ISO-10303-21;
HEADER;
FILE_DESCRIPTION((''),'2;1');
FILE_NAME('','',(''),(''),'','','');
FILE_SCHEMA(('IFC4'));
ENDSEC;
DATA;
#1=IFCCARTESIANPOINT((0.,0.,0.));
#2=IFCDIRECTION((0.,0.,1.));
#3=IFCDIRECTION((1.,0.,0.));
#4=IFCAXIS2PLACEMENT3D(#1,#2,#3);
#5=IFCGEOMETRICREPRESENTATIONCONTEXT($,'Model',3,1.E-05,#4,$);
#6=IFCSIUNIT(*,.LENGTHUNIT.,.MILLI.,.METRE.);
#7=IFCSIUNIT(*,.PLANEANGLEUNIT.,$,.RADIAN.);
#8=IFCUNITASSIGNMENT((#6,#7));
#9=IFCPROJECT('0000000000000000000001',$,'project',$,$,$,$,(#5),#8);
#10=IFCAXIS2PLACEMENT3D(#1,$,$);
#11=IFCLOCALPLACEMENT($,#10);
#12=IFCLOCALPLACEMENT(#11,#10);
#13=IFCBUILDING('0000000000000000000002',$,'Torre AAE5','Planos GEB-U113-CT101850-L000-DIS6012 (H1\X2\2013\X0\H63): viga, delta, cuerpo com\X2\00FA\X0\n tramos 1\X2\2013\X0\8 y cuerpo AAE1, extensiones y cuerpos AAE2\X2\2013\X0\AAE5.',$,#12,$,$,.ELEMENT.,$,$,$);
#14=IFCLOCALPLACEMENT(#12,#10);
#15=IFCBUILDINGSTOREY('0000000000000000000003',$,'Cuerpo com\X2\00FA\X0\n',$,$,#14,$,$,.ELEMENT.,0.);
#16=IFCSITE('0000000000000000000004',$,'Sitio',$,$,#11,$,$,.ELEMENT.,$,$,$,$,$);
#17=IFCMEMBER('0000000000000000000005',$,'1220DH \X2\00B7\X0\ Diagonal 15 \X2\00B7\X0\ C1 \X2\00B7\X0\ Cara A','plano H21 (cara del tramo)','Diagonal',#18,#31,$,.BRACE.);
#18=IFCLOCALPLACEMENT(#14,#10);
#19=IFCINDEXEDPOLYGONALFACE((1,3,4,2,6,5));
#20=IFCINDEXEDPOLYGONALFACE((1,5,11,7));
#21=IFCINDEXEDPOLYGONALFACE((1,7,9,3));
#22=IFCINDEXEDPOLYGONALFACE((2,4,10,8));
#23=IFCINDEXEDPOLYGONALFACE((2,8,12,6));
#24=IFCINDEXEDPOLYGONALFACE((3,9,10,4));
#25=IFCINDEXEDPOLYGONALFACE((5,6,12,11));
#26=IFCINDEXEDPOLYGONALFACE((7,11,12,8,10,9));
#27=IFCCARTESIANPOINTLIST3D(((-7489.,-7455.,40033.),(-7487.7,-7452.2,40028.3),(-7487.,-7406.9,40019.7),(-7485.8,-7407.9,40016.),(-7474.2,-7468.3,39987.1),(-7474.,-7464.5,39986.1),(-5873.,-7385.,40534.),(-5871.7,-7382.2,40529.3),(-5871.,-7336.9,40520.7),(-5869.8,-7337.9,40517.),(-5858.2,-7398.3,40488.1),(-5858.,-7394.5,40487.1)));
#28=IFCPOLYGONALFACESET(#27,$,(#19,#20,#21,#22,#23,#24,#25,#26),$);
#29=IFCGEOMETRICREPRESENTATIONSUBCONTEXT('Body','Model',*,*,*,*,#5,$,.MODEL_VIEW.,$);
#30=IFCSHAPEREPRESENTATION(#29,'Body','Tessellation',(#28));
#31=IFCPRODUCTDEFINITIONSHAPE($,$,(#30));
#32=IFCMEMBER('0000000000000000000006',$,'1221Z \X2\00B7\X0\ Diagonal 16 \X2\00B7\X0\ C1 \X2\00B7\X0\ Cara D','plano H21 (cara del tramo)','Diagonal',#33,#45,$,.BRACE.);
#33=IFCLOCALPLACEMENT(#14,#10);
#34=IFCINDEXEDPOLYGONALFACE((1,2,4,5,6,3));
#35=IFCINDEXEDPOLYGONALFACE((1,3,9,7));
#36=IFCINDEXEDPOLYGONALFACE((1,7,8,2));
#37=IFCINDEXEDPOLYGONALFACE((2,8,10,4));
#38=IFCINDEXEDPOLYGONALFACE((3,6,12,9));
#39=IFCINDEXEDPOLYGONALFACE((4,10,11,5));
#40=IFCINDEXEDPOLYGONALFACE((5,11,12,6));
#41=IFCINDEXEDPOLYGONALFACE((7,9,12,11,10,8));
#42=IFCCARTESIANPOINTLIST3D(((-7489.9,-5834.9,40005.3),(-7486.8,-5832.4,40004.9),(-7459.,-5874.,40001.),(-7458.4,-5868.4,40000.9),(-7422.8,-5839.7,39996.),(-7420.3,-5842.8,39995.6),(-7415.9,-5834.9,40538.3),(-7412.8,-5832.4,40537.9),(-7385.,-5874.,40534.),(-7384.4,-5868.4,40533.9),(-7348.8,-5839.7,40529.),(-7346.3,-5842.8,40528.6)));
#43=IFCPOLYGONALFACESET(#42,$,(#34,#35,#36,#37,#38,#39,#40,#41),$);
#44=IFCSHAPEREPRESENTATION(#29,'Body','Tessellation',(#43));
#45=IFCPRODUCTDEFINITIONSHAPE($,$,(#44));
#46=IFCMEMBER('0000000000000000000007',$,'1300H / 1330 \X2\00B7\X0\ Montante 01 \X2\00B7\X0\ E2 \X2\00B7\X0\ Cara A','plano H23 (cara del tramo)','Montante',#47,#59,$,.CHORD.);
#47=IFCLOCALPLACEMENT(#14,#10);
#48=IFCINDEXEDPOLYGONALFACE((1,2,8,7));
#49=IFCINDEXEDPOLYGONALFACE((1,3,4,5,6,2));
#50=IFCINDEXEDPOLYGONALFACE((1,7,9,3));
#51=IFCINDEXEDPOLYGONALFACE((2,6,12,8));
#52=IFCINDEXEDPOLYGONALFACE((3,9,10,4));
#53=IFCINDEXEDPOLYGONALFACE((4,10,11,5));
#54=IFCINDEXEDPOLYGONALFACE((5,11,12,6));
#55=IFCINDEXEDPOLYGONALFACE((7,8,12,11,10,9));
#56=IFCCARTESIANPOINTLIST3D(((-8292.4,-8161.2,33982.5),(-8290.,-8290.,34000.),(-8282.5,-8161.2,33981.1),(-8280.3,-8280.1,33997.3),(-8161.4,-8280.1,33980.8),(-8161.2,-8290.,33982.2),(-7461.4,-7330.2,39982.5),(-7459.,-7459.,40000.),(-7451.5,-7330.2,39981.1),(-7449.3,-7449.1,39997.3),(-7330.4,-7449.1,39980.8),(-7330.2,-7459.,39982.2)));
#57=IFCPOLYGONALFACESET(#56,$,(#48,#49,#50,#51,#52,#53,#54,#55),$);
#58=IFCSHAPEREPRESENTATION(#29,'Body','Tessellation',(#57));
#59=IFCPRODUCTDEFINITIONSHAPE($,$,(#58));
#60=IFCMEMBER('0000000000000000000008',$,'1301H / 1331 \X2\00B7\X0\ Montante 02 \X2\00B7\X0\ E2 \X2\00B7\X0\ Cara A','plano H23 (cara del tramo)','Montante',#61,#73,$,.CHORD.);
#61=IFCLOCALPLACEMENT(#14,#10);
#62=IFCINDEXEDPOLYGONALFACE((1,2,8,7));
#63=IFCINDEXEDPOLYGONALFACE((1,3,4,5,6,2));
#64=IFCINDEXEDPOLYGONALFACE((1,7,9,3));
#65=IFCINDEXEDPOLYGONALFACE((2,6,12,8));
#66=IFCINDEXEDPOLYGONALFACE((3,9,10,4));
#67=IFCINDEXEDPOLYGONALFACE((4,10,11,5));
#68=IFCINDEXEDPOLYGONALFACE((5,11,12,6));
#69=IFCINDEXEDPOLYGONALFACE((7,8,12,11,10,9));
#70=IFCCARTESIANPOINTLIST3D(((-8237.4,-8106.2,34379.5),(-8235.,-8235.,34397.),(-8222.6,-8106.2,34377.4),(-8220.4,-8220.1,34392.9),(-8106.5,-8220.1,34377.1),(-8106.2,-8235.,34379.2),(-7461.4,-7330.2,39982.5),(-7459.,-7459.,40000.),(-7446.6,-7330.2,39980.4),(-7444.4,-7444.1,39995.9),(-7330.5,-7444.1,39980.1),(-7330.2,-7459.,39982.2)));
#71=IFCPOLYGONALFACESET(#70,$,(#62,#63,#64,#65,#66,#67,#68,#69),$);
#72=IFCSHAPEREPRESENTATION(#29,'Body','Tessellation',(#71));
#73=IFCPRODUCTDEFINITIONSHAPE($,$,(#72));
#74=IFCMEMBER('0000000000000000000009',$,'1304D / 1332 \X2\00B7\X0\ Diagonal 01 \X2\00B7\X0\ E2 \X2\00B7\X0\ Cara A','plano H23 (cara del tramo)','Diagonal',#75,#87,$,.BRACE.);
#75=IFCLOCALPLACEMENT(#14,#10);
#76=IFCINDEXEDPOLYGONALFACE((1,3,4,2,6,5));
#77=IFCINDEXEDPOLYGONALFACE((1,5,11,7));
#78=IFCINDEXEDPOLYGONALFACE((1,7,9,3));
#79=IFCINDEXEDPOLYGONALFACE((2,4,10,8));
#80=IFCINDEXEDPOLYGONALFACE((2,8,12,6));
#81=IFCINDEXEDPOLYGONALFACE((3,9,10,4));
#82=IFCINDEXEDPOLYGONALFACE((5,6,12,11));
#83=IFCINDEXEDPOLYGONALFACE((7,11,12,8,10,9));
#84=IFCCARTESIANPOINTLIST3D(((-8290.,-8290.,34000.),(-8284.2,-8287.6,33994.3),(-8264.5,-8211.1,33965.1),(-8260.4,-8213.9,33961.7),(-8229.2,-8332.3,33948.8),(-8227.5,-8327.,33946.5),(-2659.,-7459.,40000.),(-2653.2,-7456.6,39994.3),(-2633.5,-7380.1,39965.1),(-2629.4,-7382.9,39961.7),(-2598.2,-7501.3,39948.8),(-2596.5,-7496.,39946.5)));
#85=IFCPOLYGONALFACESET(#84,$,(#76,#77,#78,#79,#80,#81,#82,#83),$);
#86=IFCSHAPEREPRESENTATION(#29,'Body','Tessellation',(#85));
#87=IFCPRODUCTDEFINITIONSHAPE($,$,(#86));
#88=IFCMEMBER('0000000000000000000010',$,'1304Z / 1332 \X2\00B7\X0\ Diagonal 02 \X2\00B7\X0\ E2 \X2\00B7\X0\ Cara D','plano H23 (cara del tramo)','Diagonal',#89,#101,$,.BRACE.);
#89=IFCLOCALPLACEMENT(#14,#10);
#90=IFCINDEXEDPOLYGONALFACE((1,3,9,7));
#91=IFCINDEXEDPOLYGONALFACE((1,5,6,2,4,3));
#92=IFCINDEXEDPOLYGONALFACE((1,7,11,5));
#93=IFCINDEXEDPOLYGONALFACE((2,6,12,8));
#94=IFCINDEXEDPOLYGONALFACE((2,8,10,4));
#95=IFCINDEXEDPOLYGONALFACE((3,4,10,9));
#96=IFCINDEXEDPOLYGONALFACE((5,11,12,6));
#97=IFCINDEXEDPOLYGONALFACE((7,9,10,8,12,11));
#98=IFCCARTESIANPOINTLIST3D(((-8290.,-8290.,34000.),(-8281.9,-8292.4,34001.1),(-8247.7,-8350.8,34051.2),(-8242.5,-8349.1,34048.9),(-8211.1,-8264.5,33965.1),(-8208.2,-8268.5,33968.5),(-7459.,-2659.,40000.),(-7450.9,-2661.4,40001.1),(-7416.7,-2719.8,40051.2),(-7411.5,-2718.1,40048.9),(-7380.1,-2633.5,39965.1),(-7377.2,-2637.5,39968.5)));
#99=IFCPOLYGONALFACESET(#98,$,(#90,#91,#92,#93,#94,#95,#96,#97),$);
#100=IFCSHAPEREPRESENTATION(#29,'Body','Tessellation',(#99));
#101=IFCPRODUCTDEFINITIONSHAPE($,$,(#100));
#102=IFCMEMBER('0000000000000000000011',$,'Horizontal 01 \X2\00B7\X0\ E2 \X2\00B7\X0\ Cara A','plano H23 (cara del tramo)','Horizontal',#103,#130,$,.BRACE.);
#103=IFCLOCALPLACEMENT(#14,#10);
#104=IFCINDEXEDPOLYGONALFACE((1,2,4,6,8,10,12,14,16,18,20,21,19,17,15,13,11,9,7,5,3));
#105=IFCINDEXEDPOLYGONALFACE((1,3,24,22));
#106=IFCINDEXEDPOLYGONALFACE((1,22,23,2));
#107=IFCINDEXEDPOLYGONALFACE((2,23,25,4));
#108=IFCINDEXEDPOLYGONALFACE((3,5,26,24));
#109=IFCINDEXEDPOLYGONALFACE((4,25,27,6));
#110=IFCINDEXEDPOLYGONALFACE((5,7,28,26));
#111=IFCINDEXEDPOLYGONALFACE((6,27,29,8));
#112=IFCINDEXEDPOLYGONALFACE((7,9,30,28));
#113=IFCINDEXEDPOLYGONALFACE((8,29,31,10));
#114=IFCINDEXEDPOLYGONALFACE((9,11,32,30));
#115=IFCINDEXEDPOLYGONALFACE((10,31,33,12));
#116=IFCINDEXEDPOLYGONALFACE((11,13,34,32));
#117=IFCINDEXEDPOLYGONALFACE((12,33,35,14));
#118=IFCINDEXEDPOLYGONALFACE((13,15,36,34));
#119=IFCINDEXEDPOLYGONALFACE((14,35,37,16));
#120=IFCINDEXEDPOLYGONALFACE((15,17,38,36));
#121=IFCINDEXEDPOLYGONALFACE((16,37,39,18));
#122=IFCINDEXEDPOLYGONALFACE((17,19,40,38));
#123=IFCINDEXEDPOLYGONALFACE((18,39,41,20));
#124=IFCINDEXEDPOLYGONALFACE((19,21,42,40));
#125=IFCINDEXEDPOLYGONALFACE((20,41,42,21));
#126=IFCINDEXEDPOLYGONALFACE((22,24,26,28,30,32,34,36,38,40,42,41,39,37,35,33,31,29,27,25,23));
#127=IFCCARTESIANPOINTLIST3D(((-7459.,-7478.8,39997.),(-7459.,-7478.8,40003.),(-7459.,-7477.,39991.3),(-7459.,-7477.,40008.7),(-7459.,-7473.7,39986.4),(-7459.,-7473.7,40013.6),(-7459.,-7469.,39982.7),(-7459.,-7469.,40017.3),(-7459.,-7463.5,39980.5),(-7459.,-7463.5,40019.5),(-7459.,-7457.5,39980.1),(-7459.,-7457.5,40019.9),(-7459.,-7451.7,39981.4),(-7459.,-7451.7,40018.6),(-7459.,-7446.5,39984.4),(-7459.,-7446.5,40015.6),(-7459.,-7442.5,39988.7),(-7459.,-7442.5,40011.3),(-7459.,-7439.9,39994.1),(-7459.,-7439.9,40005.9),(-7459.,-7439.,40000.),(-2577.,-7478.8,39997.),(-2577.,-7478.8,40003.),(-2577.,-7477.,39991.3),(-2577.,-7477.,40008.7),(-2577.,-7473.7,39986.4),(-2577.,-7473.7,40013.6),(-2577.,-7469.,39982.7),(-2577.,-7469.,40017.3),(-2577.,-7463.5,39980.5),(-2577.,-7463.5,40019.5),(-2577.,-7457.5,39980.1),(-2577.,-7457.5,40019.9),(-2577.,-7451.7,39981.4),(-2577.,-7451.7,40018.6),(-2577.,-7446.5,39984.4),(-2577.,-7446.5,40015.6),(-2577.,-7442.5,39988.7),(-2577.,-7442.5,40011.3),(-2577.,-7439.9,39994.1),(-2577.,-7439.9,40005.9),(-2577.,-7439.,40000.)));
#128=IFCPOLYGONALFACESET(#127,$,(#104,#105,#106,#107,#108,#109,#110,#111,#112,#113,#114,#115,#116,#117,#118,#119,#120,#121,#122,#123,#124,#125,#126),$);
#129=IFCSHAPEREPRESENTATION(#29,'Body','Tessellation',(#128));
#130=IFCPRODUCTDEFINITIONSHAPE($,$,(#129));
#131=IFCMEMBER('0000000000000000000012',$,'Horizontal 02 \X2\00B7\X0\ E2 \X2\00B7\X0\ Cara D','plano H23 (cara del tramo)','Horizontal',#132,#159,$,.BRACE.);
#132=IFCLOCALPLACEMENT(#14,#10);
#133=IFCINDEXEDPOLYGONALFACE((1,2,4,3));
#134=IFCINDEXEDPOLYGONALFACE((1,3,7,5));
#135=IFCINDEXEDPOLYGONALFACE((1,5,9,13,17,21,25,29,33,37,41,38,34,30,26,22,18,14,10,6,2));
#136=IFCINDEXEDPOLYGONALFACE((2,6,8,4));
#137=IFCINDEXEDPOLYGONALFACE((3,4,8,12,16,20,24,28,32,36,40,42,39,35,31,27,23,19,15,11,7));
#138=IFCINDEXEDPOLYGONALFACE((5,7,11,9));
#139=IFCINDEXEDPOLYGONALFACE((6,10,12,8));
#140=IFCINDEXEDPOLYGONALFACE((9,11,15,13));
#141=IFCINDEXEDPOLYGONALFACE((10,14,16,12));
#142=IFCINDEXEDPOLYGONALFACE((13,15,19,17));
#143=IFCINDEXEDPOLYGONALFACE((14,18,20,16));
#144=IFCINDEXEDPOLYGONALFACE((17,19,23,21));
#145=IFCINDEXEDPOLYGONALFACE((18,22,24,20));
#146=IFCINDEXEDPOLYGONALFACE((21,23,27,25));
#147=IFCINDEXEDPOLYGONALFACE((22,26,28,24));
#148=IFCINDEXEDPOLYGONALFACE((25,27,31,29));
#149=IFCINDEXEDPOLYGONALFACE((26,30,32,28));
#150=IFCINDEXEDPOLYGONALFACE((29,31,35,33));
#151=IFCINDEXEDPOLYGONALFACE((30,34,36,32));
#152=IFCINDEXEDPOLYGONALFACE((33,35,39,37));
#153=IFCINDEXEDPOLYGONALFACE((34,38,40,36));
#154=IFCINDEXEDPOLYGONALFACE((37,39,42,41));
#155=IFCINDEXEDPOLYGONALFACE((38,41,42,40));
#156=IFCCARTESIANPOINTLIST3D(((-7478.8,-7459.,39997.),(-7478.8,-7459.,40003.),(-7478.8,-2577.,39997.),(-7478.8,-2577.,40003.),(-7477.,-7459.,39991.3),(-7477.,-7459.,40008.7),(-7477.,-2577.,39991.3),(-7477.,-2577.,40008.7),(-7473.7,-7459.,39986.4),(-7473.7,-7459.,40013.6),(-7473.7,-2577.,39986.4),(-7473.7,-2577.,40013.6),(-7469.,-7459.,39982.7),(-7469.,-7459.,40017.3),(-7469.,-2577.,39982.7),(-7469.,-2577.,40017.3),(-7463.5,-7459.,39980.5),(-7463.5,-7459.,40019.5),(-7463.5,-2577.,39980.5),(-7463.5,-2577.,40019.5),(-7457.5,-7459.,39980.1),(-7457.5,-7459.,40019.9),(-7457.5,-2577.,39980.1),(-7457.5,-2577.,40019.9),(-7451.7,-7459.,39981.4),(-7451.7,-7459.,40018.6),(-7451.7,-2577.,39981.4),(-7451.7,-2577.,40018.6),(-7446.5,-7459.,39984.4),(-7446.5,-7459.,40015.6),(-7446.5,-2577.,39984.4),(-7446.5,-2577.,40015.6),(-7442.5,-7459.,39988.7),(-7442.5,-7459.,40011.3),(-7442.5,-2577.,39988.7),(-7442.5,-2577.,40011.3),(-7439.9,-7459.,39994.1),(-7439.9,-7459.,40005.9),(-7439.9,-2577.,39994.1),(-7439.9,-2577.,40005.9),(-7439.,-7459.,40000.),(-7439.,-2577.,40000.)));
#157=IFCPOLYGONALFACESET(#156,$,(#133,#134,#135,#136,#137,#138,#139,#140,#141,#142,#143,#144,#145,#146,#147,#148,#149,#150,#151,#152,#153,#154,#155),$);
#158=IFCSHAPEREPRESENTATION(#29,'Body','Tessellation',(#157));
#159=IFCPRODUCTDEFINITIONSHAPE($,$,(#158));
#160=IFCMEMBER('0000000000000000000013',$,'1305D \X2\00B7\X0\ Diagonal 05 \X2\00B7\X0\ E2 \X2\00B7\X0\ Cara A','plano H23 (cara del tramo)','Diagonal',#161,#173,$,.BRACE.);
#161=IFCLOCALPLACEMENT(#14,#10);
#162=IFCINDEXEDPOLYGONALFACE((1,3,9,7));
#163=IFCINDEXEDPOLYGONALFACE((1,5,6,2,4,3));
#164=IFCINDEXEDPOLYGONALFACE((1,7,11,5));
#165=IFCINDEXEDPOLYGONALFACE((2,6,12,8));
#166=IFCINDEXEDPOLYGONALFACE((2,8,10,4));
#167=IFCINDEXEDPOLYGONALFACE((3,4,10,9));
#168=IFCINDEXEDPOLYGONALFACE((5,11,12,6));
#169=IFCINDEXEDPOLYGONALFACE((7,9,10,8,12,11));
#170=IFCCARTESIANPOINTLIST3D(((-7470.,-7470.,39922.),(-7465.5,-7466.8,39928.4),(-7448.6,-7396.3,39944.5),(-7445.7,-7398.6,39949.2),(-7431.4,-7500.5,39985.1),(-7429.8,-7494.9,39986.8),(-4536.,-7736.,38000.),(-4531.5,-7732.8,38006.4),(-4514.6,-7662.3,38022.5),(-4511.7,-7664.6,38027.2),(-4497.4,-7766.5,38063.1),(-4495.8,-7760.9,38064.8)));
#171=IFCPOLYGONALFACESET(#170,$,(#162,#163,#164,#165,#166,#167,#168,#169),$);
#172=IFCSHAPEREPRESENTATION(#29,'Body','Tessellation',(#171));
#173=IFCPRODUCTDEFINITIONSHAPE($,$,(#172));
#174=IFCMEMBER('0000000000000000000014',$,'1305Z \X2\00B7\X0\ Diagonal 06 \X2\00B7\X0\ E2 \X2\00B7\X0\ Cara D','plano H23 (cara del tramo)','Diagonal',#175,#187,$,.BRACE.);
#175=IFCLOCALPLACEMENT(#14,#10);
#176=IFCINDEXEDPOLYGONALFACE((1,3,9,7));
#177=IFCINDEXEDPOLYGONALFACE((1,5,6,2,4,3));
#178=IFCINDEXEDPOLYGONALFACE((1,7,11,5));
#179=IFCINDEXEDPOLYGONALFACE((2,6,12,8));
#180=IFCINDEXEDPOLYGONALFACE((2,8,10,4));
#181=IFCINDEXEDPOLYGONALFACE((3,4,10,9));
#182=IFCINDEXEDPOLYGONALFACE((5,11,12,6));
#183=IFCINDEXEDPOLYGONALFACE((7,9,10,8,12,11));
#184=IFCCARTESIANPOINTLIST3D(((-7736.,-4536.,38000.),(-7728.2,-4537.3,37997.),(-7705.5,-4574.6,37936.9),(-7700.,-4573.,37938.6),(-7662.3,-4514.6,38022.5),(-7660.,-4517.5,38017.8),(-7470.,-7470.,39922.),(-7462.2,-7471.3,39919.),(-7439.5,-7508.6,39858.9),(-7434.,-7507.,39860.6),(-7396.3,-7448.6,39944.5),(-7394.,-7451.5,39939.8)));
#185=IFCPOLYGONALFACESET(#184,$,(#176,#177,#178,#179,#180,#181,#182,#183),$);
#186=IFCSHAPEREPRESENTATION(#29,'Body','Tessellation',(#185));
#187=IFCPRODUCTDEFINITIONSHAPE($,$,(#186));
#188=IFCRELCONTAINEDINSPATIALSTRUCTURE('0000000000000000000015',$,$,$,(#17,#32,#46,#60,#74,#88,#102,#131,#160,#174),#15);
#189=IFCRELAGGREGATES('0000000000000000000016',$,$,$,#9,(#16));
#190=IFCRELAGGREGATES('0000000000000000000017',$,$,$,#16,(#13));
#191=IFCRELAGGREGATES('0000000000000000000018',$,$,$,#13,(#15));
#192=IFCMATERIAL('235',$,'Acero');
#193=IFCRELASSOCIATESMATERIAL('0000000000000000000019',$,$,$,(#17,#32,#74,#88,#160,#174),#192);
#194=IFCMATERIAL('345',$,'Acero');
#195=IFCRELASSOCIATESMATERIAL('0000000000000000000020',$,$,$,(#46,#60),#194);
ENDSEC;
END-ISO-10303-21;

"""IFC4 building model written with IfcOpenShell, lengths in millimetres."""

from ifc_helpers import new_model, si_unit, frame, frame_2d, origin, origin_with_axes, place, context, subcontext, project, spatial, circle, l_section, extrude, material, element, save


model = new_model("IFC4")

# Units and contexts
model_context = context("Model", 3, precision=1e-05, world=origin_with_axes())
body_context = subcontext(model_context, "Body", "Model", "MODEL_VIEW")
ifc_project = project(units=[si_unit("LENGTHUNIT", "METRE", prefix="MILLI"), si_unit("PLANEANGLEUNIT", "RADIAN")], contexts=[model_context])

# Site, building, storey
site_placement = place(None, origin())
site = spatial("IfcSite", under=ifc_project, at=site_placement, Name="Sitio", CompositionType="ELEMENT")
building_placement = place(site_placement, origin())
building = spatial("IfcBuilding", under=site, at=building_placement, Name="Torre AAE5", Description="Planos GEB-U113-CT101850-L000-DIS6012 (H1–H63): viga, delta, cuerpo común tramos 1–8 y cuerpo AAE1, extensiones y cuerpos AAE2–AAE5.", CompositionType="ELEMENT")
storey_placement = place(building_placement, origin())
storey = spatial("IfcBuildingStorey", under=building, at=storey_placement, Name="Cuerpo común", CompositionType="ELEMENT", Elevation=0.0)

# Members
ifc_material_1 = material(Name="345", Category="Acero")
ifc_material_2 = material(Name="235", Category="Acero")
member_1_placement = place(storey_placement, frame((-5873.0, -7385.0, 40534.0), z_axis=(-0.954334, -0.041339, -0.295867), x_axis=(0.040915, 0.962961, -0.266519)))
element("IfcMember", 1, at=member_1_placement, inside=storey, material=ifc_material_2, Name="1220DH · Diagonal 15 · C1 · Cara A", Description="plano H21 (cara del tramo)", ObjectType="Diagonal", PredefinedType="BRACE", context=body_context, shape_type="SweptSolid", body=[
    extrude(l_section(Depth=50.0, Width=50.0, Thickness=4.0, at=frame_2d((25.0, 25.0))), None, (0.0, 0.0, 1.0), 1693.3),
])
member_2_placement = place(storey_placement, frame((-7459.0, -5874.0, 40001.0), z_axis=(0.137518, 0.0, 0.990499), x_axis=(0.773819, 0.624229, -0.107435)))
element("IfcMember", 2, at=member_2_placement, inside=storey, material=ifc_material_2, Name="1221Z · Diagonal 16 · C1 · Cara D", Description="plano H21 (cara del tramo)", ObjectType="Diagonal", PredefinedType="BRACE", context=body_context, shape_type="SweptSolid", body=[
    extrude(l_section(Depth=50.0, Width=50.0, Thickness=4.0, at=frame_2d((25.0, 25.0))), None, (0.0, 0.0, 1.0), 538.1),
])
member_3_placement = place(storey_placement, frame((-7459.0, -7459.0, 40000.0), z_axis=(-0.135917, -0.135917, -0.981353), x_axis=(-0.018647, 0.99072, -0.134632)))
element("IfcMember", 3, at=member_3_placement, inside=storey, material=ifc_material_1, Name="1300H / 1330 · Montante 01 · E2 · Cara A", Description="plano H23 (cara del tramo)", ObjectType="Montante", PredefinedType="CHORD", context=body_context, shape_type="SweptSolid", body=[
    extrude(l_section(Depth=130.0, Width=130.0, Thickness=10.0, at=frame_2d((65.0, 65.0))), None, (0.0, 0.0, 1.0), 6114.0),
])
member_4_placement = place(storey_placement, frame((-7459.0, -7459.0, 40000.0), z_axis=(-0.135915, -0.135915, -0.981353), x_axis=(-0.018646, 0.990721, -0.13463)))
element("IfcMember", 4, at=member_4_placement, inside=storey, material=ifc_material_1, Name="1301H / 1331 · Montante 02 · E2 · Cara A", Description="plano H23 (cara del tramo)", ObjectType="Montante", PredefinedType="CHORD", context=body_context, shape_type="SweptSolid", body=[
    extrude(l_section(Depth=130.0, Width=130.0, Thickness=15.0, at=frame_2d((65.0, 65.0))), None, (0.0, 0.0, 1.0), 5709.5),
])
for number, where, z_axis, x_axis, name in (
    (5, (-2659.0, -7459.0, 40000.0), (-0.680866, -0.100479, -0.725483), (0.283466, 0.877196, -0.387524), "1304D / 1332 · Diagonal 01 · E2 · Cara A"),
    (6, (-7459.0, -2659.0, 40000.0), (-0.100479, -0.680866, -0.725483), (0.877196, 0.283466, -0.387524), "1304Z / 1332 · Diagonal 02 · E2 · Cara D"),
):
    element("IfcMember", number, at=place(storey_placement, frame(where, z_axis=z_axis, x_axis=x_axis)), inside=storey, material=ifc_material_2, Name=name, Description="plano H23 (cara del tramo)", ObjectType="Diagonal", PredefinedType="BRACE", context=body_context, shape_type="SweptSolid", body=[
        extrude(l_section(Depth=90.0, Width=90.0, Thickness=6.0, at=frame_2d((45.0, 45.0))), None, (0.0, 0.0, 1.0), 8270.4),
    ])
for number, where, z_axis, x_axis, name in (
    (7, (-7459.0, -7459.0, 40000.0), (1.0, 0.0, 0.0), (0.0, 1.0, 0.0), "Horizontal 01 · E2 · Cara A"),
    (8, (-7459.0, -7459.0, 40000.0), (0.0, 1.0, 0.0), (1.0, 0.0, 0.0), "Horizontal 02 · E2 · Cara D"),
):
    element("IfcMember", number, at=place(storey_placement, frame(where, z_axis=z_axis, x_axis=x_axis)), inside=storey, Name=name, Description="plano H23 (cara del tramo)", ObjectType="Horizontal", PredefinedType="BRACE", context=body_context, shape_type="SweptSolid", body=[
        extrude(circle(Radius=20.0), None, (0.0, 0.0, 1.0), 4882.0),
    ])
for number, where, z_axis, x_axis, name in (
    (9, (-7470.0, -7470.0, 39922.0), (0.834102, -0.075621, -0.546402), (0.267724, 0.921564, 0.281148), "1305D · Diagonal 05 · E2 · Cara A"),
    (10, (-7470.0, -7470.0, 39922.0), (-0.075621, 0.834102, -0.546402), (0.921564, 0.267724, 0.281148), "1305Z · Diagonal 06 · E2 · Cara D"),
):
    element("IfcMember", number, at=place(storey_placement, frame(where, z_axis=z_axis, x_axis=x_axis)), inside=storey, material=ifc_material_2, Name=name, Description="plano H23 (cara del tramo)", ObjectType="Diagonal", PredefinedType="BRACE", context=body_context, shape_type="SweptSolid", body=[
        extrude(l_section(Depth=80.0, Width=80.0, Thickness=6.0, at=frame_2d((40.0, 40.0))), None, (0.0, 0.0, 1.0), 3517.6),
    ])

save(model, "model.ifc")
